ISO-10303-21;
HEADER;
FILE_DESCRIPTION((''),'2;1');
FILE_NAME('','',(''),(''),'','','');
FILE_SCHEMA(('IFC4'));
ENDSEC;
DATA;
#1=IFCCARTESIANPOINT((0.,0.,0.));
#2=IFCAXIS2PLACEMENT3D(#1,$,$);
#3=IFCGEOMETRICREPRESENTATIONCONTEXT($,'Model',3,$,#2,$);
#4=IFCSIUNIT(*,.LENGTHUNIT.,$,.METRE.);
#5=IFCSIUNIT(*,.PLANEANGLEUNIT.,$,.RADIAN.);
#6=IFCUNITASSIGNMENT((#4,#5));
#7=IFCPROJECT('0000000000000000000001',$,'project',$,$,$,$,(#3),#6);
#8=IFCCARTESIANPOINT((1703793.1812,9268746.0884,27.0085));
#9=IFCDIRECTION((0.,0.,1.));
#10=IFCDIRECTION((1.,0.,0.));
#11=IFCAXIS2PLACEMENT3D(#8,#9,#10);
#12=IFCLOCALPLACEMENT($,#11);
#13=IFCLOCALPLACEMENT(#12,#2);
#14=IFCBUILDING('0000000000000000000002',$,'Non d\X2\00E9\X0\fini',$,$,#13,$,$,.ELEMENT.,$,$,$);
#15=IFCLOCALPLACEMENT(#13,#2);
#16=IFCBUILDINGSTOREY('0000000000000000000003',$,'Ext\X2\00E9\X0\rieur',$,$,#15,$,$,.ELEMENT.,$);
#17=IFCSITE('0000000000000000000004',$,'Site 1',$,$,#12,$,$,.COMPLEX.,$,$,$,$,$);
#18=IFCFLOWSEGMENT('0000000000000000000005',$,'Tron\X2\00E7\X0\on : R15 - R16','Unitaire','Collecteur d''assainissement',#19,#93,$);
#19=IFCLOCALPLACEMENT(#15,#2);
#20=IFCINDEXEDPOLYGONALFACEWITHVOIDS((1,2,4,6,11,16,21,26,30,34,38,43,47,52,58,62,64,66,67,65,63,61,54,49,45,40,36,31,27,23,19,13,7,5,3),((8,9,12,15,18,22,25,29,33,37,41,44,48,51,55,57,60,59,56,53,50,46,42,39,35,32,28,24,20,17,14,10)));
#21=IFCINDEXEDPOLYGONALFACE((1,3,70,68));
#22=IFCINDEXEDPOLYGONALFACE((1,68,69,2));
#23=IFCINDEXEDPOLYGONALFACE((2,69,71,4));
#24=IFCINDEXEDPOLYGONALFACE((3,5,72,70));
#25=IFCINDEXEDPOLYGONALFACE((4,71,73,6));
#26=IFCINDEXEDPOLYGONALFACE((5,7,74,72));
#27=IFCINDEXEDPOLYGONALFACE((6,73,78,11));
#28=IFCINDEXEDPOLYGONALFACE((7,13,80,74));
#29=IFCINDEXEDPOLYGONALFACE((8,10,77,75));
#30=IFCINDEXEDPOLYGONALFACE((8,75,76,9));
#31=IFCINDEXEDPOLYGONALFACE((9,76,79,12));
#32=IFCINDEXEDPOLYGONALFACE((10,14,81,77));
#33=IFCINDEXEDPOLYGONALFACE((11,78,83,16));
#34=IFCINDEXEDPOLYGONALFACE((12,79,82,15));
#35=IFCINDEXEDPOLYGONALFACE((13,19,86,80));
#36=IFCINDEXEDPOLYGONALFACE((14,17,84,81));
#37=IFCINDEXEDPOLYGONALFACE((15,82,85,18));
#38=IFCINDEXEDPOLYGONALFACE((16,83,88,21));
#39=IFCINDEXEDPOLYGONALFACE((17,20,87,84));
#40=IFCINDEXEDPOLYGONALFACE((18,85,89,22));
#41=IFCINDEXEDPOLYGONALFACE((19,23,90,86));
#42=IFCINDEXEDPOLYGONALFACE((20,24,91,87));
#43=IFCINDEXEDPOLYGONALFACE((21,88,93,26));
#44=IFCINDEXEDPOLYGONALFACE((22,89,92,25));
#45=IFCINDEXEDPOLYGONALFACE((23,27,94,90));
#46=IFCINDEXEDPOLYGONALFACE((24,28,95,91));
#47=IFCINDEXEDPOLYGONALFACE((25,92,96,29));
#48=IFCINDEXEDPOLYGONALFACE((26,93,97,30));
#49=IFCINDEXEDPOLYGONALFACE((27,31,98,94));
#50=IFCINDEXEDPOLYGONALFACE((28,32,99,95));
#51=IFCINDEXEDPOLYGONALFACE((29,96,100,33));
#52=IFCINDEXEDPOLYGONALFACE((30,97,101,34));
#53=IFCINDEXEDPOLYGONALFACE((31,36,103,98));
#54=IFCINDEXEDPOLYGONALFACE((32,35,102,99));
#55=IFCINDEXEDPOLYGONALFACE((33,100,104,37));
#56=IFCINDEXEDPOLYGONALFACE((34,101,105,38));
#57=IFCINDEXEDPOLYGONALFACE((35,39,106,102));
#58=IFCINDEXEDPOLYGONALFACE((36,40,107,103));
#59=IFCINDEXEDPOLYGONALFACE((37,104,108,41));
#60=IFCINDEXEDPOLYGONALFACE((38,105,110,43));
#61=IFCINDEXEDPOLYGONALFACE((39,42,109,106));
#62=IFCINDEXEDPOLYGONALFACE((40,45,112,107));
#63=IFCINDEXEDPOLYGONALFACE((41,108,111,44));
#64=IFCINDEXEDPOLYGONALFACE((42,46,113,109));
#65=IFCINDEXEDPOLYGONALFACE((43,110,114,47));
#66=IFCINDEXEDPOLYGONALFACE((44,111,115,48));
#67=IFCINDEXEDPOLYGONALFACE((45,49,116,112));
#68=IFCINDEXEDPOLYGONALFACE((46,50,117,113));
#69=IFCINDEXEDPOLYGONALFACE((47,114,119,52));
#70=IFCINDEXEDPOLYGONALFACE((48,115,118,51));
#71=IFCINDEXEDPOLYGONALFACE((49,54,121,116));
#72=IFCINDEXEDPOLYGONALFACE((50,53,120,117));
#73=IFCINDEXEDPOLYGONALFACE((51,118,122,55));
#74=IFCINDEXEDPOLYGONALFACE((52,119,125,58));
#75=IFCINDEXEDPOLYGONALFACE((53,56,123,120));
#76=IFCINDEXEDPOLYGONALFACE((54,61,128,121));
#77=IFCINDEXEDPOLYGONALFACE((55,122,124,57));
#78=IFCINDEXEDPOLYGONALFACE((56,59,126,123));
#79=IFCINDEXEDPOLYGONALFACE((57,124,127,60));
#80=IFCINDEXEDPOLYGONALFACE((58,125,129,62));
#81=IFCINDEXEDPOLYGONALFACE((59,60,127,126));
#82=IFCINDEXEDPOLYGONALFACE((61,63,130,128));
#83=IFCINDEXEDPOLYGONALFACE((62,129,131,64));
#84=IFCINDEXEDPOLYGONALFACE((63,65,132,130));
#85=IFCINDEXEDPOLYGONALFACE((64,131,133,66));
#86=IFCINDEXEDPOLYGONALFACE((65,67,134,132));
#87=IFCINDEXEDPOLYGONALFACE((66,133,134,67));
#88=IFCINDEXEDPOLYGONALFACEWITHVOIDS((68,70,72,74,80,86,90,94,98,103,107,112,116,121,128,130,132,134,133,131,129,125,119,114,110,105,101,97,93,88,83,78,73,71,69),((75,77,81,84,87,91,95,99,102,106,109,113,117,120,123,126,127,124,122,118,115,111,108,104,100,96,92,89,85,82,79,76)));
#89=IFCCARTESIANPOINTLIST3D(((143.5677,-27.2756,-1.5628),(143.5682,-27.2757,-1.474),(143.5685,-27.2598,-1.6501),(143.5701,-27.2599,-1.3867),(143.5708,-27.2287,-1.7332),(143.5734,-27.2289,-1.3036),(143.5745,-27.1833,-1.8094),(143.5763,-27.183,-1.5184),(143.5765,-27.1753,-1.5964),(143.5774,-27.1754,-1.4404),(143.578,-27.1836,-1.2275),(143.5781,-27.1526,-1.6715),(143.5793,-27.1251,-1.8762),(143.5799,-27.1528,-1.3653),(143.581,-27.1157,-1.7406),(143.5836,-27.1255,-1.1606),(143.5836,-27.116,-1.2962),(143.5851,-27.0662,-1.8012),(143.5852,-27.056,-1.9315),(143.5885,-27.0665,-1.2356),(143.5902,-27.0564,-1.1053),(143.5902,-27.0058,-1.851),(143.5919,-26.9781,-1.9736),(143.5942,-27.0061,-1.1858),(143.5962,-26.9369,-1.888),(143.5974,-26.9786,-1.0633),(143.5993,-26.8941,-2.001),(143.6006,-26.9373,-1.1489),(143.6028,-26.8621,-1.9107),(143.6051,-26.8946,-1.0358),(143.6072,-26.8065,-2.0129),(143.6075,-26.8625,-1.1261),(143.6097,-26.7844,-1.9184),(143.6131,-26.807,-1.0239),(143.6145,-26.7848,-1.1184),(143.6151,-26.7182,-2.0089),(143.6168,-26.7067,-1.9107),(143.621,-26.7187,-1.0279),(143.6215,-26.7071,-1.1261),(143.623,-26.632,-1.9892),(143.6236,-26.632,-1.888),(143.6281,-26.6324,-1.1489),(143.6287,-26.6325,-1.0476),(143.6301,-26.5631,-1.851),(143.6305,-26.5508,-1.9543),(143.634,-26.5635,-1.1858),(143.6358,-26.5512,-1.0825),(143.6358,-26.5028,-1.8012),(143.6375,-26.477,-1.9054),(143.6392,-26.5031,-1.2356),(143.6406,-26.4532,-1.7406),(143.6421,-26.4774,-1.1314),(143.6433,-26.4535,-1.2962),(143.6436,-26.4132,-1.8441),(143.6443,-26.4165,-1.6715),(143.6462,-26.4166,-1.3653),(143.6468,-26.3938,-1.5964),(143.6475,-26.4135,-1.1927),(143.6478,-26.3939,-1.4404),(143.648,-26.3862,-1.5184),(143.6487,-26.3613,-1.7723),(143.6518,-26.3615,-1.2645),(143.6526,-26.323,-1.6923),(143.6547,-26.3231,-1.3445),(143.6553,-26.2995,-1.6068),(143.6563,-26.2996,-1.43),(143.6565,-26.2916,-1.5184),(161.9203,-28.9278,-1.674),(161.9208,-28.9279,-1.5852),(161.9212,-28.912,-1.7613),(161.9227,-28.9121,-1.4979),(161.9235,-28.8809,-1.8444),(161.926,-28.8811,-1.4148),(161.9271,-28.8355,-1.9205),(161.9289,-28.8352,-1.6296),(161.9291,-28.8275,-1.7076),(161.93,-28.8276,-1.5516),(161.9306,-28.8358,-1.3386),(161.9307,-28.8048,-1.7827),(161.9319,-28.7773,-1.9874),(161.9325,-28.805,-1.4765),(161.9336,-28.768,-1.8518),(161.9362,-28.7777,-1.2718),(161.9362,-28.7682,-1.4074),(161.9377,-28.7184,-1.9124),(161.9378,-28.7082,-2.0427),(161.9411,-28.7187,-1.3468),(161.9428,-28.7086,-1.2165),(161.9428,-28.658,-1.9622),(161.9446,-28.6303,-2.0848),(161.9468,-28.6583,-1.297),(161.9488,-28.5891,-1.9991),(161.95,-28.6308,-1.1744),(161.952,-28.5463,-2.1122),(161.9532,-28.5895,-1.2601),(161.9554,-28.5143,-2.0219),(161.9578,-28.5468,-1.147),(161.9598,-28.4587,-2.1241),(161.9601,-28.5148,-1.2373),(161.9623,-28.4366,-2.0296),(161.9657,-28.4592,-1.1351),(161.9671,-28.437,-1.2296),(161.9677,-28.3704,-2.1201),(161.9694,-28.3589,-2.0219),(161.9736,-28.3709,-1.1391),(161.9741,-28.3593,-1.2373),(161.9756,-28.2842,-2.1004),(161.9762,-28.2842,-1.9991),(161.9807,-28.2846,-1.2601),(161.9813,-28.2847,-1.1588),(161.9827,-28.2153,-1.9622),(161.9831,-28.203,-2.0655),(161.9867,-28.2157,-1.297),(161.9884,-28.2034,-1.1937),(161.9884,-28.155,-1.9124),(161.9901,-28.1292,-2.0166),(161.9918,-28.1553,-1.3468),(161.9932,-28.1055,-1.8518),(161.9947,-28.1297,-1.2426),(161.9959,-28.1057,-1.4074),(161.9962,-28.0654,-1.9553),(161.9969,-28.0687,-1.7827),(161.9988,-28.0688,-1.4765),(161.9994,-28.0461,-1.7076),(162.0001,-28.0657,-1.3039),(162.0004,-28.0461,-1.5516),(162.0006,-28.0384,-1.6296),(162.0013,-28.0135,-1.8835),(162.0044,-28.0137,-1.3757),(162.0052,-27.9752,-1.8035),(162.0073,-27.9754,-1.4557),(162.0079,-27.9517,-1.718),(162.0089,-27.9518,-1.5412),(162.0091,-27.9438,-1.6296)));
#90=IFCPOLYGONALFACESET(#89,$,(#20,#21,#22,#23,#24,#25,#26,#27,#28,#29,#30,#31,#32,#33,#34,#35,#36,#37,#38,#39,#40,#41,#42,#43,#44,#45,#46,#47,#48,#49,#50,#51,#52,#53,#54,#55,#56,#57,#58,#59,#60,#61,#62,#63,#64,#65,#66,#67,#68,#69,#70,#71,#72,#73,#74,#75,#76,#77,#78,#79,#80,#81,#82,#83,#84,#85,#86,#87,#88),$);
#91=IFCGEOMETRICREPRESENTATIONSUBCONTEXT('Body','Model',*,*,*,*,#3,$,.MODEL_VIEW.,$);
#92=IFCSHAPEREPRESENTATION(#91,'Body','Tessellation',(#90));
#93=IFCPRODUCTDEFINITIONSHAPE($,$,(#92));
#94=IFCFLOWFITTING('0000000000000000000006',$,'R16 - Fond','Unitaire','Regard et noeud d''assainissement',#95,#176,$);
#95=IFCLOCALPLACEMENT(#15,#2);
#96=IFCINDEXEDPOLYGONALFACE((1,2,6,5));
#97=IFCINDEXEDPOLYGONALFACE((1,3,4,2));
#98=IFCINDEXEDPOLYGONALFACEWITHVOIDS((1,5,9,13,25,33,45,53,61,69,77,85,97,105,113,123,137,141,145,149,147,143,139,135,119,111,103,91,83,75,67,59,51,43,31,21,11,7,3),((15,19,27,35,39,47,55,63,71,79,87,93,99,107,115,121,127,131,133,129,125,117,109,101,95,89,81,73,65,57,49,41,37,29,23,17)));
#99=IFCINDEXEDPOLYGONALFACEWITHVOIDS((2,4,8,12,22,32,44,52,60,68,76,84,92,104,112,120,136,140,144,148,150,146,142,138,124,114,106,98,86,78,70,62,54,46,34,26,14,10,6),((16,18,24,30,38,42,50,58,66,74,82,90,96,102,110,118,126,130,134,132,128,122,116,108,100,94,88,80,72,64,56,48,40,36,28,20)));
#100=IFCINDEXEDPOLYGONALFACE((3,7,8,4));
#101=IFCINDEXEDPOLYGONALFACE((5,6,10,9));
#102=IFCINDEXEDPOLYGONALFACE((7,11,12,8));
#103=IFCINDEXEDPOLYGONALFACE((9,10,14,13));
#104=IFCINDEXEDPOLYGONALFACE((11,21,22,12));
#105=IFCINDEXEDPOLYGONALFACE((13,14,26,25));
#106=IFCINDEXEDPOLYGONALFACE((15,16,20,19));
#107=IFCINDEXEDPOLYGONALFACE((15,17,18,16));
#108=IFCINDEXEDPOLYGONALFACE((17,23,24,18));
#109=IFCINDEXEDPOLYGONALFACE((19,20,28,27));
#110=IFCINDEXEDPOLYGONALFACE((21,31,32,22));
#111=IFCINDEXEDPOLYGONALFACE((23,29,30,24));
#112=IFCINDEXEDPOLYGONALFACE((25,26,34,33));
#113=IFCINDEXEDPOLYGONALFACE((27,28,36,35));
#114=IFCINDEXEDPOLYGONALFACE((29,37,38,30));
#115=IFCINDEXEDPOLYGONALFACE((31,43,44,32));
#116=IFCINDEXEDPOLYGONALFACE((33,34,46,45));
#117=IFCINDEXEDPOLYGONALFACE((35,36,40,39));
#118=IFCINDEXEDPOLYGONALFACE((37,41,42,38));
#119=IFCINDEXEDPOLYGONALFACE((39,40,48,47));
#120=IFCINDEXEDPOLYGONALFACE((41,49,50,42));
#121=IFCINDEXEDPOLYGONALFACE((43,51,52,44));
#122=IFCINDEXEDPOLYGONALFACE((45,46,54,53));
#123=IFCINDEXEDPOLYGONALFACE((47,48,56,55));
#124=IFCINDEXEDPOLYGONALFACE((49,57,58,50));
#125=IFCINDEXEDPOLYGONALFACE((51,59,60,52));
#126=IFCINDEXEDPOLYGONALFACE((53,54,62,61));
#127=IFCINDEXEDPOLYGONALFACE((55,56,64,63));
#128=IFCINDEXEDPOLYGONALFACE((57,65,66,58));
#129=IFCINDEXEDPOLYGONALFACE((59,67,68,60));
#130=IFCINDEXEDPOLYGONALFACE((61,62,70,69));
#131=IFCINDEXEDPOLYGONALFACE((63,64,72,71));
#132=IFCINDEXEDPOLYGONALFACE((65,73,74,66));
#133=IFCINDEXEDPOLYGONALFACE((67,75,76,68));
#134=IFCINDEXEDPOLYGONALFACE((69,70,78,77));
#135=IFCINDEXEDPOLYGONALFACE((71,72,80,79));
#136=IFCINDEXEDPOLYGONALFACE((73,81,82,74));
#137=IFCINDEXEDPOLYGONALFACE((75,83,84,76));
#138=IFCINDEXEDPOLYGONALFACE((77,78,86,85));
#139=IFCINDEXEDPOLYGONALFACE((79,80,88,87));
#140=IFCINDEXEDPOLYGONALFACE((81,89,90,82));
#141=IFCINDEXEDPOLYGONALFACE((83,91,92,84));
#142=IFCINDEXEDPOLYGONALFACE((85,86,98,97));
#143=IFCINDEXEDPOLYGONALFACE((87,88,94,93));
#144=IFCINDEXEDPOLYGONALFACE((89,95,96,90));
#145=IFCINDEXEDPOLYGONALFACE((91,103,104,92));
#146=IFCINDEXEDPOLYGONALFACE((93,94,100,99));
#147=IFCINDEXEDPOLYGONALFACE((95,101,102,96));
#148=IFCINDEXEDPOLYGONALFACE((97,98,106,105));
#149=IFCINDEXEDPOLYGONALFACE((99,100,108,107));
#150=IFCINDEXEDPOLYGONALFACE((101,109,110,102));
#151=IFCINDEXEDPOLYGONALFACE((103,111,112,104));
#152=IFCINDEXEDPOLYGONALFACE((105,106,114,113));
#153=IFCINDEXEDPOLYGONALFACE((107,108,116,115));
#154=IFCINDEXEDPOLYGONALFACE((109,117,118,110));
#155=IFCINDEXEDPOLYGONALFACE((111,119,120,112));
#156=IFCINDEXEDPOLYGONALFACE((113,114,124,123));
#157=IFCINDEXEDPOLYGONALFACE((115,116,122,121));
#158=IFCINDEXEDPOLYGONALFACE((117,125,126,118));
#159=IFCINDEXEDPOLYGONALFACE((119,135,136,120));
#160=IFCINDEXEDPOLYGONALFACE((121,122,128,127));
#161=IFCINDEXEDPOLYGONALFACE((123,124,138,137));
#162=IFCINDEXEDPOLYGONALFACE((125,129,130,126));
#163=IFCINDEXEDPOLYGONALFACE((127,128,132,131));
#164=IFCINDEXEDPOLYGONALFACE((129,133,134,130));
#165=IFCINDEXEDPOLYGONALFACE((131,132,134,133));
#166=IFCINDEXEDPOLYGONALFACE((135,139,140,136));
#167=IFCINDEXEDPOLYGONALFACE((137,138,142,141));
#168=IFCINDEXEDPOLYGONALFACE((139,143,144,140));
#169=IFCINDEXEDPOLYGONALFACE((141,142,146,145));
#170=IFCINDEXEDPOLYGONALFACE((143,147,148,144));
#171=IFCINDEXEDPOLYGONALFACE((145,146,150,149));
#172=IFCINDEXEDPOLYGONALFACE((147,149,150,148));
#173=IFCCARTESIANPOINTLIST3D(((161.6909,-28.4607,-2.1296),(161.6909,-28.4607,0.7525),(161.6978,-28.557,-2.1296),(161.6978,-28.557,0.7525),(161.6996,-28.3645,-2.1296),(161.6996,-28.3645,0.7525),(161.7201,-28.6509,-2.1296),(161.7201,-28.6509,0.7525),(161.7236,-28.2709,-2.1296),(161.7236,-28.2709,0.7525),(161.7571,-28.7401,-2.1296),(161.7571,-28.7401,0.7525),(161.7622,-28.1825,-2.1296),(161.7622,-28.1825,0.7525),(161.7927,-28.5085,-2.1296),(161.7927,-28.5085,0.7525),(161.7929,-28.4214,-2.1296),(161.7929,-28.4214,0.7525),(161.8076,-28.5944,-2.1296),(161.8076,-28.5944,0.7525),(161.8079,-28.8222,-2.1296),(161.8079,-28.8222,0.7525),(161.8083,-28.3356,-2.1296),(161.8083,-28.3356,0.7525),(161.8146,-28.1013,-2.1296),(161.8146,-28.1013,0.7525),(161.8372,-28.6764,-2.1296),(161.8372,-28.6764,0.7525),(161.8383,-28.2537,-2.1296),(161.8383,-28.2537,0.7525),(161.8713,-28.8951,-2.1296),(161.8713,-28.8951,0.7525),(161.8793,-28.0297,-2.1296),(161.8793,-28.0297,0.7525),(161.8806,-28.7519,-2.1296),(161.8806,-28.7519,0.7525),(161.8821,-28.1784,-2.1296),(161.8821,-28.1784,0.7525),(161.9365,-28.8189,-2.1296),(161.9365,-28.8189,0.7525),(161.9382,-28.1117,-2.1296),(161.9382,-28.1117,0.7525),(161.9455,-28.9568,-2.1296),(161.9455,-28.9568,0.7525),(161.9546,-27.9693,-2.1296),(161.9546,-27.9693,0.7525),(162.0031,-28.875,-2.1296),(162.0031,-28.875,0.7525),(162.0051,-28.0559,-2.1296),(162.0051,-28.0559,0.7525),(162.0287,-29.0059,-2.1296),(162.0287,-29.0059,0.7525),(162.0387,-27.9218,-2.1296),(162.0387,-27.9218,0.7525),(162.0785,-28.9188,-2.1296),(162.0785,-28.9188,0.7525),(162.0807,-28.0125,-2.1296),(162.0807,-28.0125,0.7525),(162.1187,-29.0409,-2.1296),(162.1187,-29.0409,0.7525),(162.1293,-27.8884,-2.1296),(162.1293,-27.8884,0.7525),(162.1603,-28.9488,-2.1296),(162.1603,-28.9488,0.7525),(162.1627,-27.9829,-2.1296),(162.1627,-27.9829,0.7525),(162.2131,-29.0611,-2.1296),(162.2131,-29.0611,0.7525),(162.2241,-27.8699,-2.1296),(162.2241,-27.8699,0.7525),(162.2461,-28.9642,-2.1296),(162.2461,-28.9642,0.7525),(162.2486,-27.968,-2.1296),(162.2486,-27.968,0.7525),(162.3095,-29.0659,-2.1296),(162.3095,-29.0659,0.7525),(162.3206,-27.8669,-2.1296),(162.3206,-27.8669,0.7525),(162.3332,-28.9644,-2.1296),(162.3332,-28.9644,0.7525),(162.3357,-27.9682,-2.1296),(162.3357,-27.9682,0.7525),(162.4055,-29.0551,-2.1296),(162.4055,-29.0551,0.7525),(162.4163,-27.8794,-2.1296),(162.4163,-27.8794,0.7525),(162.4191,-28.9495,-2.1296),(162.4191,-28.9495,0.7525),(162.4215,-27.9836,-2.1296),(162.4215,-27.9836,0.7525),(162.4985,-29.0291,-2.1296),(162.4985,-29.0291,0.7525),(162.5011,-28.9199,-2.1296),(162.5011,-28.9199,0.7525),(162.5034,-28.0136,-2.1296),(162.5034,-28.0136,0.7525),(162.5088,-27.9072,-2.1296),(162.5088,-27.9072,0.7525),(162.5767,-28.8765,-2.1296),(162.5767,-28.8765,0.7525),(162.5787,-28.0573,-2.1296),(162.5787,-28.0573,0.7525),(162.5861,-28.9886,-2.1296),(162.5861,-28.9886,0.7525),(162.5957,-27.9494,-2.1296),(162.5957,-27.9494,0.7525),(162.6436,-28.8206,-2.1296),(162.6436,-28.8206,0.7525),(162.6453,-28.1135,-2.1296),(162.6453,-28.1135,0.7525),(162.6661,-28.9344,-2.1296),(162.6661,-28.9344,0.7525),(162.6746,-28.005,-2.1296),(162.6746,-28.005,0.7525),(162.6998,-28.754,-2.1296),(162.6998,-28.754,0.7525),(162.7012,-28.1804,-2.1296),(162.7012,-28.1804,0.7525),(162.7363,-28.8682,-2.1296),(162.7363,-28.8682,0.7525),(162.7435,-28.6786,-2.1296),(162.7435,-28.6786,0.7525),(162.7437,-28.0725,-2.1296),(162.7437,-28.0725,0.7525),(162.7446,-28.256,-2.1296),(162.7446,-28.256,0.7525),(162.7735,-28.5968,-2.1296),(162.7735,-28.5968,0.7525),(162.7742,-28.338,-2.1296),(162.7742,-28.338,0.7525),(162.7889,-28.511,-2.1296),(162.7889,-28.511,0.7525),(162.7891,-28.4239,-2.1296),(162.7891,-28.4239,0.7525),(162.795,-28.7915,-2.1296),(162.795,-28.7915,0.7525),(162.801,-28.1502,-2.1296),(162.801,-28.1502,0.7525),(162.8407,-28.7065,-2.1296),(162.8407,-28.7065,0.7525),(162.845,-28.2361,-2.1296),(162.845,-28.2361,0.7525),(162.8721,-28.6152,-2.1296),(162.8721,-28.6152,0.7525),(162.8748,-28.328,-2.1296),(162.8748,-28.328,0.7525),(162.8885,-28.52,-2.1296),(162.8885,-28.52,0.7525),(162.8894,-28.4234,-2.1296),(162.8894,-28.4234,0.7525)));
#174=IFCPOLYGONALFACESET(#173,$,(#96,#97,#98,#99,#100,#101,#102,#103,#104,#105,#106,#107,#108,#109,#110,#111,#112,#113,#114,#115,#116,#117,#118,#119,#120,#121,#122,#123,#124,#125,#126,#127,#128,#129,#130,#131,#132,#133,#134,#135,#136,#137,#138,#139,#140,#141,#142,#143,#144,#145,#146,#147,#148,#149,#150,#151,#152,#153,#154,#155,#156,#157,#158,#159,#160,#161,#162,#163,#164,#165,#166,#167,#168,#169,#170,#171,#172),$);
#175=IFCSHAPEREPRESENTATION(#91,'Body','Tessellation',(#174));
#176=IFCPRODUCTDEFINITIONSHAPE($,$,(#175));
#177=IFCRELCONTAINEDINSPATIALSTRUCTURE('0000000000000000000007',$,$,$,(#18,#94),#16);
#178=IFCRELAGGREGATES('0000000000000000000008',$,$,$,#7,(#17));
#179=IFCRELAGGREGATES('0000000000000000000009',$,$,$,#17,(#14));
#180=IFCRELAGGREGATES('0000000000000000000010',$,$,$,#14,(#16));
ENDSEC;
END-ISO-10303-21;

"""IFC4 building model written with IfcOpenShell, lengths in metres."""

from ifc_helpers import new_model, si_unit, frame, origin, origin_2d, place, context, subcontext, project, spatial, hollow_circle, extrude, element, save


model = new_model("IFC4")

# Units and contexts
model_context = context("Model", 3, world=origin())
body_context = subcontext(model_context, "Body", "Model", "MODEL_VIEW")
ifc_project = project(units=[si_unit("LENGTHUNIT", "METRE"), si_unit("PLANEANGLEUNIT", "RADIAN")], contexts=[model_context])

# Site, building, storey
site_placement = place(None, frame((1703793.1812, 9268746.0884, 27.0085), z_axis=(0.0, 0.0, 1.0), x_axis=(1.0, 0.0, 0.0)))
site = spatial("IfcSite", under=ifc_project, at=site_placement, Name="Site 1", CompositionType="COMPLEX")
building_placement = place(site_placement, origin())
building = spatial("IfcBuilding", under=site, at=building_placement, Name="Non défini", CompositionType="ELEMENT")
storey_placement = place(building_placement, origin())
storey = spatial("IfcBuildingStorey", under=building, at=storey_placement, Name="Extérieur", CompositionType="ELEMENT")

# Flow segment
flow_segment_1_placement = place(storey_placement, origin())
element("IfcFlowSegment", 1, at=flow_segment_1_placement, inside=storey, Name="Tronçon : R15 - R16", Description="Unitaire", ObjectType="Collecteur d'assainissement", context=body_context, shape_type="SweptSolid", body=[
    extrude(hollow_circle(Radius=0.495, WallThickness=0.095, at=origin_2d()), frame((143.6121, -26.7846, -1.5184), z_axis=(0.995954, -0.089662, -0.006034), x_axis=(0.089663, 0.995972, 0.0)), (0.0, 0.0, 1.0), 18.4272),
])

# Flow fitting
flow_fitting_1_placement = place(storey_placement, origin())
element("IfcFlowFitting", 2, at=flow_fitting_1_placement, inside=storey, Name="R16 - Fond", Description="Unitaire", ObjectType="Regard et noeud d'assainissement", context=body_context, shape_type="SweptSolid", body=[
    extrude(hollow_circle(Radius=0.6, WallThickness=0.1, at=origin_2d()), frame((162.2909, -28.4662, -2.1296), z_axis=(0.0, 0.0, 1.0), x_axis=(0.995972, -0.089663, 0.0)), (0.0, 0.0, 1.0), 2.8821),
])

save(model, "model.ifc")
